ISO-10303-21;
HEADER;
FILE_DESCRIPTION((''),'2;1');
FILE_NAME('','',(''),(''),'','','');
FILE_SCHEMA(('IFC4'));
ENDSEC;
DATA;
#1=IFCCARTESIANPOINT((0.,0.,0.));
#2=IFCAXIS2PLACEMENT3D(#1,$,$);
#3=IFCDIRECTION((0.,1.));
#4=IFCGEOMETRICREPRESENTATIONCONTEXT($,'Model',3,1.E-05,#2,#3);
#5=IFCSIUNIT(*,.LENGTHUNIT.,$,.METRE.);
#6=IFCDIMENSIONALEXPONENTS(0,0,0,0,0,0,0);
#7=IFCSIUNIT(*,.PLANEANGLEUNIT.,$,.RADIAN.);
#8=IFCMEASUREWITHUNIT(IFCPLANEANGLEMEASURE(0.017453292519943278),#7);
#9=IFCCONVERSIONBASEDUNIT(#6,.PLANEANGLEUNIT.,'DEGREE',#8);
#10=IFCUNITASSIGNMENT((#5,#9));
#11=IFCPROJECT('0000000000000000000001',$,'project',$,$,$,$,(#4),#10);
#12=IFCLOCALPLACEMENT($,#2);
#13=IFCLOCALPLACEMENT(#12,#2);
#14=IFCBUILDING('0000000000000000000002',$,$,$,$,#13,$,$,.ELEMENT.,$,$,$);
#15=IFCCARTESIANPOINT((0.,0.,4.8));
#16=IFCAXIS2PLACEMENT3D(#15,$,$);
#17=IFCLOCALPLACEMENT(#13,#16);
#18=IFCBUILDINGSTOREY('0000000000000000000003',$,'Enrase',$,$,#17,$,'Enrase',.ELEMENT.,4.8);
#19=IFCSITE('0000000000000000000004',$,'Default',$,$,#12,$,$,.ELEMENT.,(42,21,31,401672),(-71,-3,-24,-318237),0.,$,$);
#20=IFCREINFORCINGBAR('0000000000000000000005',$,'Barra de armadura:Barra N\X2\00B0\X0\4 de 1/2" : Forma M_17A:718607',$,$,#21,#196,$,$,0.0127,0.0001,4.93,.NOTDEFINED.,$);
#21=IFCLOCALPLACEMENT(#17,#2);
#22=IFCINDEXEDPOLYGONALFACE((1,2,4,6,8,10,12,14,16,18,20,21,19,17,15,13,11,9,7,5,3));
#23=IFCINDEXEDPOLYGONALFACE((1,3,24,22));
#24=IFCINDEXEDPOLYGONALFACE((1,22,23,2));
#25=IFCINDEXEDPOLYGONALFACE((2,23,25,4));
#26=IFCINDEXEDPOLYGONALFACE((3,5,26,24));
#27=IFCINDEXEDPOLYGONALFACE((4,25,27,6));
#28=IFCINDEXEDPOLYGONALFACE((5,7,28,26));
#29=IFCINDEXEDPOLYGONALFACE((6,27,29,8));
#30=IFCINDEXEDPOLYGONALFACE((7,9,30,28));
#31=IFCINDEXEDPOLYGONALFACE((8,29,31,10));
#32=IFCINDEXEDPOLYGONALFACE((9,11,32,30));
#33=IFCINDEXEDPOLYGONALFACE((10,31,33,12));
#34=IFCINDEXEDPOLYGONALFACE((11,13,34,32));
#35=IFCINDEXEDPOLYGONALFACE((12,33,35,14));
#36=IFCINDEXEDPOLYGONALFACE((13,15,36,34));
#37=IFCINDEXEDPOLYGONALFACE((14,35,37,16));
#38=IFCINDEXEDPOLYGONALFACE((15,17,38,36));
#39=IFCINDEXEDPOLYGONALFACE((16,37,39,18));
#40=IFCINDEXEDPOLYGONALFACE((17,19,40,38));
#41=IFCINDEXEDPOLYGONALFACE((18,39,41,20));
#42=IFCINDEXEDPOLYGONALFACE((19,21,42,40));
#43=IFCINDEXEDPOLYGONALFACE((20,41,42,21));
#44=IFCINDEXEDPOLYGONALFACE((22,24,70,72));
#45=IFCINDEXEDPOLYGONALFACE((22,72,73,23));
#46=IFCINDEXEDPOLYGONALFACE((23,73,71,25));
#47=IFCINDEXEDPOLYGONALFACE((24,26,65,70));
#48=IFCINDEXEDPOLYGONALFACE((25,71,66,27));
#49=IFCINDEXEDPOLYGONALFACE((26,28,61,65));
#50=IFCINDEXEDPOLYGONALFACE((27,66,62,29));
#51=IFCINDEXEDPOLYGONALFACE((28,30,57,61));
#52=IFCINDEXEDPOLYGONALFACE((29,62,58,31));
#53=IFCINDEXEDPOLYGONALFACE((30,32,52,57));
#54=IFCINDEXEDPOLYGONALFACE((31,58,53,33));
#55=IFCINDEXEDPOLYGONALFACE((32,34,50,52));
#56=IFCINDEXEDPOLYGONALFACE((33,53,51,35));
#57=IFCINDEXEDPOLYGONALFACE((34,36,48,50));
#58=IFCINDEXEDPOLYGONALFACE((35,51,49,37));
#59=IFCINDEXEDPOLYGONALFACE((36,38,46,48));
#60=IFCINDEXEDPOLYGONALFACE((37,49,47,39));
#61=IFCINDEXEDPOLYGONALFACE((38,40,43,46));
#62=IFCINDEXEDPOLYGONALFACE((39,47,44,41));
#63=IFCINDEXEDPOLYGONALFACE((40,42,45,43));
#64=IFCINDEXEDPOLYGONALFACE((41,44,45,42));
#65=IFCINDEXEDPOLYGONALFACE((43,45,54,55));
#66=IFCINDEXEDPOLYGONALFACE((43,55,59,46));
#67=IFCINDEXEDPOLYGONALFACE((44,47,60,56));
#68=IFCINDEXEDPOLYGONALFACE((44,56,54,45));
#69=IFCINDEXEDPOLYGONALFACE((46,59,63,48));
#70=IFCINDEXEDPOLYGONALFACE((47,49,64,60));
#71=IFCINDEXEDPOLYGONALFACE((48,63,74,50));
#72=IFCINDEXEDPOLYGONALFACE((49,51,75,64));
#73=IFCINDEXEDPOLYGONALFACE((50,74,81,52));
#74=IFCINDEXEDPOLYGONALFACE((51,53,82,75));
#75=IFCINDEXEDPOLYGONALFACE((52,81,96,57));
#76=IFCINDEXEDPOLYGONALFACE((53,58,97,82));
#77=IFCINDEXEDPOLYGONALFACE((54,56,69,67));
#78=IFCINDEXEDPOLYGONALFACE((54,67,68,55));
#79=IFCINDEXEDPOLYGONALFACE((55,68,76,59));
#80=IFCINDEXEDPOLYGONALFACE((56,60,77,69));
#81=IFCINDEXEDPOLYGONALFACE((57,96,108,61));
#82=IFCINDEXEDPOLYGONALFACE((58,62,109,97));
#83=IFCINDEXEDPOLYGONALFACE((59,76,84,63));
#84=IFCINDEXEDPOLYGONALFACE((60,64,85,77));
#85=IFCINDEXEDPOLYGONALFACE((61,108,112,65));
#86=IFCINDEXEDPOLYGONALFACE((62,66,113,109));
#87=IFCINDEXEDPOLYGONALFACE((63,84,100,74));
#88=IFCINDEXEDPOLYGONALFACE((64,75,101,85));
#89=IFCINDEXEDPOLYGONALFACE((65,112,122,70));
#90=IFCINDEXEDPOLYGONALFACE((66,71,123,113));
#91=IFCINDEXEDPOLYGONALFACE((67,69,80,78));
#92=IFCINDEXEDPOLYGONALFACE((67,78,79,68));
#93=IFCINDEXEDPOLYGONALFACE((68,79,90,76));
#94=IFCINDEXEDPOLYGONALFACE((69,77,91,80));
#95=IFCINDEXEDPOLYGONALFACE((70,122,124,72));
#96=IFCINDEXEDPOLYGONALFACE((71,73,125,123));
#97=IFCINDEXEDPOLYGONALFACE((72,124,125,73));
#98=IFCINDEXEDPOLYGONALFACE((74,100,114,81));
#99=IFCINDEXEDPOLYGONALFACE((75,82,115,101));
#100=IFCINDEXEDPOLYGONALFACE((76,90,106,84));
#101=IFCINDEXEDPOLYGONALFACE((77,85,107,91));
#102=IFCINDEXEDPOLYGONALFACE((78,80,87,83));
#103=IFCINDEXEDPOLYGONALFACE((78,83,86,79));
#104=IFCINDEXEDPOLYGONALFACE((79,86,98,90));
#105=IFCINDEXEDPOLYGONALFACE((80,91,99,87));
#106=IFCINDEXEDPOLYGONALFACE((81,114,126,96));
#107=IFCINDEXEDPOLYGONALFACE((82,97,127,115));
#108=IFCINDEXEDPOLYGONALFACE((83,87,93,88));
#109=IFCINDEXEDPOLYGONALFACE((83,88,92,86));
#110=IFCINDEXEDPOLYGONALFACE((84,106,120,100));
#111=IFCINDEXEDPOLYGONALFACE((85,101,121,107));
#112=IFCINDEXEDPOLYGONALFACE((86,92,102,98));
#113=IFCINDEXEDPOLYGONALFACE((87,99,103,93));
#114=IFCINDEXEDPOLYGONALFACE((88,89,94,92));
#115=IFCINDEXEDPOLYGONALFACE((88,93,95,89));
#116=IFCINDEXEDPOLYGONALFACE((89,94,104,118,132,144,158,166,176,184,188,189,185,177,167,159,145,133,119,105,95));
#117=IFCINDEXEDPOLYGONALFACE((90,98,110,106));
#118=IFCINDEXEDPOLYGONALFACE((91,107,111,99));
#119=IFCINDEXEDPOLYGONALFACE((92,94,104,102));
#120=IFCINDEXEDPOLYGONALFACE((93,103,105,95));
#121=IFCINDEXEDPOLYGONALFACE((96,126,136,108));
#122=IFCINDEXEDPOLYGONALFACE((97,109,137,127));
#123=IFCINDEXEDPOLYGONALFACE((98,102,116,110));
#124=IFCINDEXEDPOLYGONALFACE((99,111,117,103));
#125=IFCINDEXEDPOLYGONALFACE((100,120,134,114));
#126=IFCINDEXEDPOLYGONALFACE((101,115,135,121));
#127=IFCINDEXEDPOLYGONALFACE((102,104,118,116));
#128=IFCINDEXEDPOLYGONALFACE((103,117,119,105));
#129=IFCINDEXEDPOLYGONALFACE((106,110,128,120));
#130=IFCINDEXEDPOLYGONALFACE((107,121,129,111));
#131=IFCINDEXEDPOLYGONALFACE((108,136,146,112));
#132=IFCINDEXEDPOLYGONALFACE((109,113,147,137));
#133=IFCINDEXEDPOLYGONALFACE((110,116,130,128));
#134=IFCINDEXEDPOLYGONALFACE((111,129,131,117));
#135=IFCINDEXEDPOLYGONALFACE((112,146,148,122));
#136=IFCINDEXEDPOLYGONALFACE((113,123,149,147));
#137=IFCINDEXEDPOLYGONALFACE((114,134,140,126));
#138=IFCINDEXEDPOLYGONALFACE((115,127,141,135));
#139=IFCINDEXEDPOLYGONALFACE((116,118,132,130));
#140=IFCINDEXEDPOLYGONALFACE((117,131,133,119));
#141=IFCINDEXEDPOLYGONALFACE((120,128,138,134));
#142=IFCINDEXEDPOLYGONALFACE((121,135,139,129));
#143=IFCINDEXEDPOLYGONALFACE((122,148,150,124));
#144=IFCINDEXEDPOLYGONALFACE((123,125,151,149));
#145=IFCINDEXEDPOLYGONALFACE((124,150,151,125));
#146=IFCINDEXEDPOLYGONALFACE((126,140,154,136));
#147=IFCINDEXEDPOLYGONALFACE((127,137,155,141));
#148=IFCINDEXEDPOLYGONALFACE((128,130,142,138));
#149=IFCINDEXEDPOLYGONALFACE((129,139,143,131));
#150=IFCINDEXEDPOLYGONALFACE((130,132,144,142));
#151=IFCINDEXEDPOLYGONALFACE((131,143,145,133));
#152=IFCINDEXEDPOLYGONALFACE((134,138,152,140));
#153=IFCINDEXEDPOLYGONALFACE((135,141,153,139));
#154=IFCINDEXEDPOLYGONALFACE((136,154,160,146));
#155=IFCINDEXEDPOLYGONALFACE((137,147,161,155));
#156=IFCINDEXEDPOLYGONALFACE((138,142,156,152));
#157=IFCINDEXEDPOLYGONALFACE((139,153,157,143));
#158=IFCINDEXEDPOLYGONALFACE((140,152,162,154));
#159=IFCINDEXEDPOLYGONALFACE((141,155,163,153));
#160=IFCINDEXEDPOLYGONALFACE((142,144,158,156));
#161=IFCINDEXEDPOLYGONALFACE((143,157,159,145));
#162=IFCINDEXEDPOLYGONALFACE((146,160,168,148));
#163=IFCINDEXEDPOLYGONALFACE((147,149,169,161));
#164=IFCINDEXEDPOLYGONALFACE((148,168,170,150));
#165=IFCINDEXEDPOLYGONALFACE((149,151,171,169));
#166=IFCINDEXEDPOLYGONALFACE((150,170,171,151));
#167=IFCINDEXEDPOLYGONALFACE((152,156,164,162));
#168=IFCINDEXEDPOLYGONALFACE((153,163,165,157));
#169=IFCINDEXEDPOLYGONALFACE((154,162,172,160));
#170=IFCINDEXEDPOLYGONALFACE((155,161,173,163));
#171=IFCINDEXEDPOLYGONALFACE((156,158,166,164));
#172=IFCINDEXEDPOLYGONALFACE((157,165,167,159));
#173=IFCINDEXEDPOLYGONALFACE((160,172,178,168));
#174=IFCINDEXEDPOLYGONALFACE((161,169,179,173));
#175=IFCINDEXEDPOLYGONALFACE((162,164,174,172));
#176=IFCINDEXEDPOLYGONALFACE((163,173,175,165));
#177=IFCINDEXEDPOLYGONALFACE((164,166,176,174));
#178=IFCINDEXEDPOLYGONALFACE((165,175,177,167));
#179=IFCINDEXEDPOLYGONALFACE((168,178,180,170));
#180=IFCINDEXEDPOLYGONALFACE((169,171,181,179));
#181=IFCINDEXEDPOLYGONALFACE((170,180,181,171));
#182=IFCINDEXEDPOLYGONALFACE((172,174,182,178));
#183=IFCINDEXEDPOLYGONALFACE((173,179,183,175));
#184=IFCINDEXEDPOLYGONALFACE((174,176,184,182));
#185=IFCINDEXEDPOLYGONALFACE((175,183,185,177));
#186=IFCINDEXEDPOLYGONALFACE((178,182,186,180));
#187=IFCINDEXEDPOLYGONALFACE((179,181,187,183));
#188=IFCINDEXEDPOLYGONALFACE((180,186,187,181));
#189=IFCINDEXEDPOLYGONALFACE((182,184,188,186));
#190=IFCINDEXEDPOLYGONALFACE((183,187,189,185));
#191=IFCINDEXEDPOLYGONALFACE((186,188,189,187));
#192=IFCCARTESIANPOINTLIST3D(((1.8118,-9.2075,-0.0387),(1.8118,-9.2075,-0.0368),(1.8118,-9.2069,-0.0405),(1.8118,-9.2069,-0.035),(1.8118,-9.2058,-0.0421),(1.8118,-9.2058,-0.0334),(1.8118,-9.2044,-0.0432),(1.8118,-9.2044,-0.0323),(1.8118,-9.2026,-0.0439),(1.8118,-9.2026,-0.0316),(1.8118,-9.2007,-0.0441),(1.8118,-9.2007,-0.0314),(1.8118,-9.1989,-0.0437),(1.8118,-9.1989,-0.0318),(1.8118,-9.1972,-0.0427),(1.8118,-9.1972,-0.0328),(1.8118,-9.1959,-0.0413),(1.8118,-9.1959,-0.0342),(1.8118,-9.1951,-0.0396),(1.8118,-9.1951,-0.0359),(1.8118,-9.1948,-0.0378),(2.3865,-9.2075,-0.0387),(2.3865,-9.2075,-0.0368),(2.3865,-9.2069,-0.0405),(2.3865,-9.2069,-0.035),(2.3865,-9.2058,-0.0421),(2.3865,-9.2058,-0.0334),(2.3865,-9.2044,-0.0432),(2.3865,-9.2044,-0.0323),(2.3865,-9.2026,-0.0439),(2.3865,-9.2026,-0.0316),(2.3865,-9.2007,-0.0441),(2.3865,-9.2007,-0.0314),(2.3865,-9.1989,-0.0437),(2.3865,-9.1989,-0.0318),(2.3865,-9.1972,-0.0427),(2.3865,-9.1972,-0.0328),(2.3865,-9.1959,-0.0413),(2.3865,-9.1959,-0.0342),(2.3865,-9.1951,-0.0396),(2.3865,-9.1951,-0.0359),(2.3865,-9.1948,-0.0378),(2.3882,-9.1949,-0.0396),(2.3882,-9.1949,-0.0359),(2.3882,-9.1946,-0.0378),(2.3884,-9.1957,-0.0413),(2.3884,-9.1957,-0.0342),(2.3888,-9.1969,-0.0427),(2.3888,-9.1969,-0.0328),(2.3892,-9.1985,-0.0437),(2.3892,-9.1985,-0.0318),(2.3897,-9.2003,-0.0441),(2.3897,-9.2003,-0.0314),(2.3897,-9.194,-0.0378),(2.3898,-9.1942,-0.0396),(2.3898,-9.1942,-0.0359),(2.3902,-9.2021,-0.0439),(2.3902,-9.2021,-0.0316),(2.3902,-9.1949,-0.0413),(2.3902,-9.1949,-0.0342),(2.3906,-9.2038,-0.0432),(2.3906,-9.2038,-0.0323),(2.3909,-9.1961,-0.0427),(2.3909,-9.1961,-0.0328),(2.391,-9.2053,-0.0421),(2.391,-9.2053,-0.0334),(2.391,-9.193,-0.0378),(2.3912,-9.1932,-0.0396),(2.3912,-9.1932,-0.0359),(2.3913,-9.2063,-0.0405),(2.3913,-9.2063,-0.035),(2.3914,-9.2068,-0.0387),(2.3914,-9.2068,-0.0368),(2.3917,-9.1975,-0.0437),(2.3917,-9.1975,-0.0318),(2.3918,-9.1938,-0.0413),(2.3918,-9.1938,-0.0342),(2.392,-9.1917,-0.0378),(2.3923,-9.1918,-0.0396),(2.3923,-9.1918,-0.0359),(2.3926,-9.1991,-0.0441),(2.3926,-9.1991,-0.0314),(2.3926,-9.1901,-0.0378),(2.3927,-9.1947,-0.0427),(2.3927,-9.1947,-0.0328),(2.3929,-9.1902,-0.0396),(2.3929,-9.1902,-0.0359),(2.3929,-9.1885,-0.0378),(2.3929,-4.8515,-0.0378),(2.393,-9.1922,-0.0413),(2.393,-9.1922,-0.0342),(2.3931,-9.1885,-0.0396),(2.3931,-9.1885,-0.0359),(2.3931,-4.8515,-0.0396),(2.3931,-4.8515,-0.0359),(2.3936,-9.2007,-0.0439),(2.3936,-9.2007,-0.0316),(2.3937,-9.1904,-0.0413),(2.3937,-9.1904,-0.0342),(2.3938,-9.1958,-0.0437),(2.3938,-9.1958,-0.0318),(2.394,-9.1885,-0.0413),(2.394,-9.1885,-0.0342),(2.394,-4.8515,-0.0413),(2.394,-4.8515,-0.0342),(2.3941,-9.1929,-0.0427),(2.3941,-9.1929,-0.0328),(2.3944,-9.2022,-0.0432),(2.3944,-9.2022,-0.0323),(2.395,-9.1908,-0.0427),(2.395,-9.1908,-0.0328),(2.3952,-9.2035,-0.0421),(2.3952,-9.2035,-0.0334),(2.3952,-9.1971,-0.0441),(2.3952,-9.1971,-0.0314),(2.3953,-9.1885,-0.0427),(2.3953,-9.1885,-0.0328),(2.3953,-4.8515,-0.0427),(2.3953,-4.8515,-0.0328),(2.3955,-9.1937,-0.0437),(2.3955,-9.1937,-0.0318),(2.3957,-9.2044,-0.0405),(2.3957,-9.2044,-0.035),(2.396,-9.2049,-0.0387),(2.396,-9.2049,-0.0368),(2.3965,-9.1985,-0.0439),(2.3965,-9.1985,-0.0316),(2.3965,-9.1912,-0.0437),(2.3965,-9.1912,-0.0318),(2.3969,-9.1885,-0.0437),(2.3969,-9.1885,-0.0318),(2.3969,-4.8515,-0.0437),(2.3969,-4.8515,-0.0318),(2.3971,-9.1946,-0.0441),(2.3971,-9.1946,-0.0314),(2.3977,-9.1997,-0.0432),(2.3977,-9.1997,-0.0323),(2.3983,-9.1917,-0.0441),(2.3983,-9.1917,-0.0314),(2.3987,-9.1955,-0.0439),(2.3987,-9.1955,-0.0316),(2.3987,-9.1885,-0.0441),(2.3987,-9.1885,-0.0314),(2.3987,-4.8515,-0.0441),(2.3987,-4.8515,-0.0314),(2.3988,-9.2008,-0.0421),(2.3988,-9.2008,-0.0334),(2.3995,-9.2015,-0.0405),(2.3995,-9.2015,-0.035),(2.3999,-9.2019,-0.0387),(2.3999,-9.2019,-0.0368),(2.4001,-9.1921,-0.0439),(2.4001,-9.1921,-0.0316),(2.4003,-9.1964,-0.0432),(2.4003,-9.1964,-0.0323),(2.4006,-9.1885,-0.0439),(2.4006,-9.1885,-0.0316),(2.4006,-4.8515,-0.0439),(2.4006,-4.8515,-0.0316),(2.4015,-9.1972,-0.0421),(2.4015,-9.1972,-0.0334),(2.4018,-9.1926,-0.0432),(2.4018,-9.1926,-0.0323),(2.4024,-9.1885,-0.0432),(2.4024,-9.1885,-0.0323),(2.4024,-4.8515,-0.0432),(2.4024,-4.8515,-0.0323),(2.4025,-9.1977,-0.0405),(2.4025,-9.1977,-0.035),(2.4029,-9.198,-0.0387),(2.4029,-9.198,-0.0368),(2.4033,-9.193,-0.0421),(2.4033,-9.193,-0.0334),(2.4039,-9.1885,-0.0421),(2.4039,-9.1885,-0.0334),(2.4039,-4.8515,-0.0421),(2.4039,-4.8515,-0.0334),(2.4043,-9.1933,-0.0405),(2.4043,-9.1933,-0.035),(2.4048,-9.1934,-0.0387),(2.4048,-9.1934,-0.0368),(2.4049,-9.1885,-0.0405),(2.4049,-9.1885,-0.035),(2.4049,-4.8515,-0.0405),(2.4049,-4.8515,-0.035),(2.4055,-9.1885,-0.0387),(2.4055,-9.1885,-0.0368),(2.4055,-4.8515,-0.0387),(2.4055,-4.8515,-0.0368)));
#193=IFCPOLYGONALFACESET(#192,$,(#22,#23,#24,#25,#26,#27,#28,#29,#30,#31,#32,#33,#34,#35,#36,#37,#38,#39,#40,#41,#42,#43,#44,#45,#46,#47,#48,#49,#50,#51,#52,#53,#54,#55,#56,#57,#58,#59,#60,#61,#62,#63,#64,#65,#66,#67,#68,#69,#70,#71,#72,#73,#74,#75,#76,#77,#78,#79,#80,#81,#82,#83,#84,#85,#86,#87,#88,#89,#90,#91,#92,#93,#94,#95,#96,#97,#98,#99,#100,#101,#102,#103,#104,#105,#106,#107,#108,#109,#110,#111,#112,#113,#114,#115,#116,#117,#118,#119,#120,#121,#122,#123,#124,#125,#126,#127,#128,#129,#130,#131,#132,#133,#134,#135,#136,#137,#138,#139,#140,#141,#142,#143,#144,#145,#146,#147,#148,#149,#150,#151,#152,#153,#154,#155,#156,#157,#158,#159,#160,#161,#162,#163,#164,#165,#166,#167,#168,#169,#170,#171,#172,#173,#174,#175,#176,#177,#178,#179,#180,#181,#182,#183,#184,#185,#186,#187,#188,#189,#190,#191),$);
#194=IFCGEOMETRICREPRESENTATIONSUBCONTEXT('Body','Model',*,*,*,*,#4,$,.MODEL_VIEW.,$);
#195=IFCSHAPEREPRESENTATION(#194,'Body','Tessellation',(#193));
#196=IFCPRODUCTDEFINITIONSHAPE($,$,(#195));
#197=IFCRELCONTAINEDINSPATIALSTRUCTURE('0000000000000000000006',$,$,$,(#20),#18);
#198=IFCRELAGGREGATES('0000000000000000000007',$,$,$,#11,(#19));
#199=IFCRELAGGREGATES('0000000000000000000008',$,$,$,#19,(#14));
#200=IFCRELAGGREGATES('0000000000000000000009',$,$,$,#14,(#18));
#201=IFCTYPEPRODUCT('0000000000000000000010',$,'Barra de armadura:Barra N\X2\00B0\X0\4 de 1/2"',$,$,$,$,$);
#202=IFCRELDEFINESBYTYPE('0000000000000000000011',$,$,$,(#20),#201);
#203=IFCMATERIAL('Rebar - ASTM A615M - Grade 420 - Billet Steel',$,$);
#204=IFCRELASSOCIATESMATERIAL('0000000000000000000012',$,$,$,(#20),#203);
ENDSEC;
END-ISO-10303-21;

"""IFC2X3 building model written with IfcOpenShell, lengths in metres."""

from ifc_helpers import new_model, entity, si_unit, converted_unit, direction, frame, origin, place, context, subcontext, project, spatial, material, type_object, element, save


model = new_model("IFC2X3")

# Units and contexts
model_context = context("Model", 3, precision=1e-05, world=origin(), true_north=direction((0.0, 1.0)))
body_context = subcontext(model_context, "Body", "Model", "MODEL_VIEW")
ifc_project = project(units=[si_unit("LENGTHUNIT", "METRE"), converted_unit("PLANEANGLEUNIT", "DEGREE", entity("IfcPlaneAngleMeasure", 0.017453292519943278), si_unit("PLANEANGLEUNIT", "RADIAN"), dimensions=[0, 0, 0, 0, 0, 0, 0])], contexts=[model_context])

# Site, building, storey
site_placement = place(None, origin())
site = spatial("IfcSite", under=ifc_project, at=site_placement, Name="Default", CompositionType="ELEMENT", RefLatitude=(42, 21, 31, 401672), RefLongitude=(-71, -3, -24, -318237), RefElevation=0.0)
building_placement = place(site_placement, origin())
building = spatial("IfcBuilding", under=site, at=building_placement, CompositionType="ELEMENT")
storey_placement = place(building_placement, frame((0.0, 0.0, 4.8)))
storey = spatial("IfcBuildingStorey", under=building, at=storey_placement, Name="Enrase", LongName="Enrase", CompositionType="ELEMENT", Elevation=4.8)

# Reinforcing bar
ifc_material = material(Name="Rebar - ASTM A615M - Grade 420 - Billet Steel")
type_product_1 = type_object("IfcTypeProduct", Name="Barra de armadura:Barra N°4 de 1/2\"")
reinforcing_bar_1_placement = place(storey_placement, origin())
element("IfcReinforcingBar", 1, at=reinforcing_bar_1_placement, inside=storey, type_object=type_product_1, material=ifc_material, Name="Barra de armadura:Barra N°4 de 1/2\" : Forma M_17A:718607", BarLength=4.93, BarRole="NOTDEFINED", CrossSectionArea=0.0001, NominalDiameter=0.0127, context=body_context, shape_type="AdvancedSweptSolid", body=[
    entity("IfcSweptDiskSolid", entity("IfcCompositeCurve", [entity("IfcCompositeCurveSegment", "CONTINUOUS", True, entity("IfcPolyline", [entity("IfcCartesianPoint", [2.3992, -4.8515, -0.0378]), entity("IfcCartesianPoint", [2.3992, -9.1885, -0.0378])])), entity("IfcCompositeCurveSegment", "CONTINUOUS", True, entity("IfcTrimmedCurve", entity("IfcCircle", entity("IfcAxis2Placement3D", entity("IfcCartesianPoint", [2.3865, -9.1885, -0.0378]), entity("IfcDirection", [0.0, 0.0, -1.0]), entity("IfcDirection", [0.0, -1.0, 0.0])), 0.0127), [entity("IfcParameterValue", 270.0)], [entity("IfcParameterValue", 360.0)], True, "PARAMETER")), entity("IfcCompositeCurveSegment", "CONTINUOUS", True, entity("IfcPolyline", [entity("IfcCartesianPoint", [2.3865, -9.2012, -0.0378]), entity("IfcCartesianPoint", [1.8118, -9.2012, -0.0378])]))], False), 0.0063, None, 0.0, 92.0),
])

save(model, "model.ifc")
